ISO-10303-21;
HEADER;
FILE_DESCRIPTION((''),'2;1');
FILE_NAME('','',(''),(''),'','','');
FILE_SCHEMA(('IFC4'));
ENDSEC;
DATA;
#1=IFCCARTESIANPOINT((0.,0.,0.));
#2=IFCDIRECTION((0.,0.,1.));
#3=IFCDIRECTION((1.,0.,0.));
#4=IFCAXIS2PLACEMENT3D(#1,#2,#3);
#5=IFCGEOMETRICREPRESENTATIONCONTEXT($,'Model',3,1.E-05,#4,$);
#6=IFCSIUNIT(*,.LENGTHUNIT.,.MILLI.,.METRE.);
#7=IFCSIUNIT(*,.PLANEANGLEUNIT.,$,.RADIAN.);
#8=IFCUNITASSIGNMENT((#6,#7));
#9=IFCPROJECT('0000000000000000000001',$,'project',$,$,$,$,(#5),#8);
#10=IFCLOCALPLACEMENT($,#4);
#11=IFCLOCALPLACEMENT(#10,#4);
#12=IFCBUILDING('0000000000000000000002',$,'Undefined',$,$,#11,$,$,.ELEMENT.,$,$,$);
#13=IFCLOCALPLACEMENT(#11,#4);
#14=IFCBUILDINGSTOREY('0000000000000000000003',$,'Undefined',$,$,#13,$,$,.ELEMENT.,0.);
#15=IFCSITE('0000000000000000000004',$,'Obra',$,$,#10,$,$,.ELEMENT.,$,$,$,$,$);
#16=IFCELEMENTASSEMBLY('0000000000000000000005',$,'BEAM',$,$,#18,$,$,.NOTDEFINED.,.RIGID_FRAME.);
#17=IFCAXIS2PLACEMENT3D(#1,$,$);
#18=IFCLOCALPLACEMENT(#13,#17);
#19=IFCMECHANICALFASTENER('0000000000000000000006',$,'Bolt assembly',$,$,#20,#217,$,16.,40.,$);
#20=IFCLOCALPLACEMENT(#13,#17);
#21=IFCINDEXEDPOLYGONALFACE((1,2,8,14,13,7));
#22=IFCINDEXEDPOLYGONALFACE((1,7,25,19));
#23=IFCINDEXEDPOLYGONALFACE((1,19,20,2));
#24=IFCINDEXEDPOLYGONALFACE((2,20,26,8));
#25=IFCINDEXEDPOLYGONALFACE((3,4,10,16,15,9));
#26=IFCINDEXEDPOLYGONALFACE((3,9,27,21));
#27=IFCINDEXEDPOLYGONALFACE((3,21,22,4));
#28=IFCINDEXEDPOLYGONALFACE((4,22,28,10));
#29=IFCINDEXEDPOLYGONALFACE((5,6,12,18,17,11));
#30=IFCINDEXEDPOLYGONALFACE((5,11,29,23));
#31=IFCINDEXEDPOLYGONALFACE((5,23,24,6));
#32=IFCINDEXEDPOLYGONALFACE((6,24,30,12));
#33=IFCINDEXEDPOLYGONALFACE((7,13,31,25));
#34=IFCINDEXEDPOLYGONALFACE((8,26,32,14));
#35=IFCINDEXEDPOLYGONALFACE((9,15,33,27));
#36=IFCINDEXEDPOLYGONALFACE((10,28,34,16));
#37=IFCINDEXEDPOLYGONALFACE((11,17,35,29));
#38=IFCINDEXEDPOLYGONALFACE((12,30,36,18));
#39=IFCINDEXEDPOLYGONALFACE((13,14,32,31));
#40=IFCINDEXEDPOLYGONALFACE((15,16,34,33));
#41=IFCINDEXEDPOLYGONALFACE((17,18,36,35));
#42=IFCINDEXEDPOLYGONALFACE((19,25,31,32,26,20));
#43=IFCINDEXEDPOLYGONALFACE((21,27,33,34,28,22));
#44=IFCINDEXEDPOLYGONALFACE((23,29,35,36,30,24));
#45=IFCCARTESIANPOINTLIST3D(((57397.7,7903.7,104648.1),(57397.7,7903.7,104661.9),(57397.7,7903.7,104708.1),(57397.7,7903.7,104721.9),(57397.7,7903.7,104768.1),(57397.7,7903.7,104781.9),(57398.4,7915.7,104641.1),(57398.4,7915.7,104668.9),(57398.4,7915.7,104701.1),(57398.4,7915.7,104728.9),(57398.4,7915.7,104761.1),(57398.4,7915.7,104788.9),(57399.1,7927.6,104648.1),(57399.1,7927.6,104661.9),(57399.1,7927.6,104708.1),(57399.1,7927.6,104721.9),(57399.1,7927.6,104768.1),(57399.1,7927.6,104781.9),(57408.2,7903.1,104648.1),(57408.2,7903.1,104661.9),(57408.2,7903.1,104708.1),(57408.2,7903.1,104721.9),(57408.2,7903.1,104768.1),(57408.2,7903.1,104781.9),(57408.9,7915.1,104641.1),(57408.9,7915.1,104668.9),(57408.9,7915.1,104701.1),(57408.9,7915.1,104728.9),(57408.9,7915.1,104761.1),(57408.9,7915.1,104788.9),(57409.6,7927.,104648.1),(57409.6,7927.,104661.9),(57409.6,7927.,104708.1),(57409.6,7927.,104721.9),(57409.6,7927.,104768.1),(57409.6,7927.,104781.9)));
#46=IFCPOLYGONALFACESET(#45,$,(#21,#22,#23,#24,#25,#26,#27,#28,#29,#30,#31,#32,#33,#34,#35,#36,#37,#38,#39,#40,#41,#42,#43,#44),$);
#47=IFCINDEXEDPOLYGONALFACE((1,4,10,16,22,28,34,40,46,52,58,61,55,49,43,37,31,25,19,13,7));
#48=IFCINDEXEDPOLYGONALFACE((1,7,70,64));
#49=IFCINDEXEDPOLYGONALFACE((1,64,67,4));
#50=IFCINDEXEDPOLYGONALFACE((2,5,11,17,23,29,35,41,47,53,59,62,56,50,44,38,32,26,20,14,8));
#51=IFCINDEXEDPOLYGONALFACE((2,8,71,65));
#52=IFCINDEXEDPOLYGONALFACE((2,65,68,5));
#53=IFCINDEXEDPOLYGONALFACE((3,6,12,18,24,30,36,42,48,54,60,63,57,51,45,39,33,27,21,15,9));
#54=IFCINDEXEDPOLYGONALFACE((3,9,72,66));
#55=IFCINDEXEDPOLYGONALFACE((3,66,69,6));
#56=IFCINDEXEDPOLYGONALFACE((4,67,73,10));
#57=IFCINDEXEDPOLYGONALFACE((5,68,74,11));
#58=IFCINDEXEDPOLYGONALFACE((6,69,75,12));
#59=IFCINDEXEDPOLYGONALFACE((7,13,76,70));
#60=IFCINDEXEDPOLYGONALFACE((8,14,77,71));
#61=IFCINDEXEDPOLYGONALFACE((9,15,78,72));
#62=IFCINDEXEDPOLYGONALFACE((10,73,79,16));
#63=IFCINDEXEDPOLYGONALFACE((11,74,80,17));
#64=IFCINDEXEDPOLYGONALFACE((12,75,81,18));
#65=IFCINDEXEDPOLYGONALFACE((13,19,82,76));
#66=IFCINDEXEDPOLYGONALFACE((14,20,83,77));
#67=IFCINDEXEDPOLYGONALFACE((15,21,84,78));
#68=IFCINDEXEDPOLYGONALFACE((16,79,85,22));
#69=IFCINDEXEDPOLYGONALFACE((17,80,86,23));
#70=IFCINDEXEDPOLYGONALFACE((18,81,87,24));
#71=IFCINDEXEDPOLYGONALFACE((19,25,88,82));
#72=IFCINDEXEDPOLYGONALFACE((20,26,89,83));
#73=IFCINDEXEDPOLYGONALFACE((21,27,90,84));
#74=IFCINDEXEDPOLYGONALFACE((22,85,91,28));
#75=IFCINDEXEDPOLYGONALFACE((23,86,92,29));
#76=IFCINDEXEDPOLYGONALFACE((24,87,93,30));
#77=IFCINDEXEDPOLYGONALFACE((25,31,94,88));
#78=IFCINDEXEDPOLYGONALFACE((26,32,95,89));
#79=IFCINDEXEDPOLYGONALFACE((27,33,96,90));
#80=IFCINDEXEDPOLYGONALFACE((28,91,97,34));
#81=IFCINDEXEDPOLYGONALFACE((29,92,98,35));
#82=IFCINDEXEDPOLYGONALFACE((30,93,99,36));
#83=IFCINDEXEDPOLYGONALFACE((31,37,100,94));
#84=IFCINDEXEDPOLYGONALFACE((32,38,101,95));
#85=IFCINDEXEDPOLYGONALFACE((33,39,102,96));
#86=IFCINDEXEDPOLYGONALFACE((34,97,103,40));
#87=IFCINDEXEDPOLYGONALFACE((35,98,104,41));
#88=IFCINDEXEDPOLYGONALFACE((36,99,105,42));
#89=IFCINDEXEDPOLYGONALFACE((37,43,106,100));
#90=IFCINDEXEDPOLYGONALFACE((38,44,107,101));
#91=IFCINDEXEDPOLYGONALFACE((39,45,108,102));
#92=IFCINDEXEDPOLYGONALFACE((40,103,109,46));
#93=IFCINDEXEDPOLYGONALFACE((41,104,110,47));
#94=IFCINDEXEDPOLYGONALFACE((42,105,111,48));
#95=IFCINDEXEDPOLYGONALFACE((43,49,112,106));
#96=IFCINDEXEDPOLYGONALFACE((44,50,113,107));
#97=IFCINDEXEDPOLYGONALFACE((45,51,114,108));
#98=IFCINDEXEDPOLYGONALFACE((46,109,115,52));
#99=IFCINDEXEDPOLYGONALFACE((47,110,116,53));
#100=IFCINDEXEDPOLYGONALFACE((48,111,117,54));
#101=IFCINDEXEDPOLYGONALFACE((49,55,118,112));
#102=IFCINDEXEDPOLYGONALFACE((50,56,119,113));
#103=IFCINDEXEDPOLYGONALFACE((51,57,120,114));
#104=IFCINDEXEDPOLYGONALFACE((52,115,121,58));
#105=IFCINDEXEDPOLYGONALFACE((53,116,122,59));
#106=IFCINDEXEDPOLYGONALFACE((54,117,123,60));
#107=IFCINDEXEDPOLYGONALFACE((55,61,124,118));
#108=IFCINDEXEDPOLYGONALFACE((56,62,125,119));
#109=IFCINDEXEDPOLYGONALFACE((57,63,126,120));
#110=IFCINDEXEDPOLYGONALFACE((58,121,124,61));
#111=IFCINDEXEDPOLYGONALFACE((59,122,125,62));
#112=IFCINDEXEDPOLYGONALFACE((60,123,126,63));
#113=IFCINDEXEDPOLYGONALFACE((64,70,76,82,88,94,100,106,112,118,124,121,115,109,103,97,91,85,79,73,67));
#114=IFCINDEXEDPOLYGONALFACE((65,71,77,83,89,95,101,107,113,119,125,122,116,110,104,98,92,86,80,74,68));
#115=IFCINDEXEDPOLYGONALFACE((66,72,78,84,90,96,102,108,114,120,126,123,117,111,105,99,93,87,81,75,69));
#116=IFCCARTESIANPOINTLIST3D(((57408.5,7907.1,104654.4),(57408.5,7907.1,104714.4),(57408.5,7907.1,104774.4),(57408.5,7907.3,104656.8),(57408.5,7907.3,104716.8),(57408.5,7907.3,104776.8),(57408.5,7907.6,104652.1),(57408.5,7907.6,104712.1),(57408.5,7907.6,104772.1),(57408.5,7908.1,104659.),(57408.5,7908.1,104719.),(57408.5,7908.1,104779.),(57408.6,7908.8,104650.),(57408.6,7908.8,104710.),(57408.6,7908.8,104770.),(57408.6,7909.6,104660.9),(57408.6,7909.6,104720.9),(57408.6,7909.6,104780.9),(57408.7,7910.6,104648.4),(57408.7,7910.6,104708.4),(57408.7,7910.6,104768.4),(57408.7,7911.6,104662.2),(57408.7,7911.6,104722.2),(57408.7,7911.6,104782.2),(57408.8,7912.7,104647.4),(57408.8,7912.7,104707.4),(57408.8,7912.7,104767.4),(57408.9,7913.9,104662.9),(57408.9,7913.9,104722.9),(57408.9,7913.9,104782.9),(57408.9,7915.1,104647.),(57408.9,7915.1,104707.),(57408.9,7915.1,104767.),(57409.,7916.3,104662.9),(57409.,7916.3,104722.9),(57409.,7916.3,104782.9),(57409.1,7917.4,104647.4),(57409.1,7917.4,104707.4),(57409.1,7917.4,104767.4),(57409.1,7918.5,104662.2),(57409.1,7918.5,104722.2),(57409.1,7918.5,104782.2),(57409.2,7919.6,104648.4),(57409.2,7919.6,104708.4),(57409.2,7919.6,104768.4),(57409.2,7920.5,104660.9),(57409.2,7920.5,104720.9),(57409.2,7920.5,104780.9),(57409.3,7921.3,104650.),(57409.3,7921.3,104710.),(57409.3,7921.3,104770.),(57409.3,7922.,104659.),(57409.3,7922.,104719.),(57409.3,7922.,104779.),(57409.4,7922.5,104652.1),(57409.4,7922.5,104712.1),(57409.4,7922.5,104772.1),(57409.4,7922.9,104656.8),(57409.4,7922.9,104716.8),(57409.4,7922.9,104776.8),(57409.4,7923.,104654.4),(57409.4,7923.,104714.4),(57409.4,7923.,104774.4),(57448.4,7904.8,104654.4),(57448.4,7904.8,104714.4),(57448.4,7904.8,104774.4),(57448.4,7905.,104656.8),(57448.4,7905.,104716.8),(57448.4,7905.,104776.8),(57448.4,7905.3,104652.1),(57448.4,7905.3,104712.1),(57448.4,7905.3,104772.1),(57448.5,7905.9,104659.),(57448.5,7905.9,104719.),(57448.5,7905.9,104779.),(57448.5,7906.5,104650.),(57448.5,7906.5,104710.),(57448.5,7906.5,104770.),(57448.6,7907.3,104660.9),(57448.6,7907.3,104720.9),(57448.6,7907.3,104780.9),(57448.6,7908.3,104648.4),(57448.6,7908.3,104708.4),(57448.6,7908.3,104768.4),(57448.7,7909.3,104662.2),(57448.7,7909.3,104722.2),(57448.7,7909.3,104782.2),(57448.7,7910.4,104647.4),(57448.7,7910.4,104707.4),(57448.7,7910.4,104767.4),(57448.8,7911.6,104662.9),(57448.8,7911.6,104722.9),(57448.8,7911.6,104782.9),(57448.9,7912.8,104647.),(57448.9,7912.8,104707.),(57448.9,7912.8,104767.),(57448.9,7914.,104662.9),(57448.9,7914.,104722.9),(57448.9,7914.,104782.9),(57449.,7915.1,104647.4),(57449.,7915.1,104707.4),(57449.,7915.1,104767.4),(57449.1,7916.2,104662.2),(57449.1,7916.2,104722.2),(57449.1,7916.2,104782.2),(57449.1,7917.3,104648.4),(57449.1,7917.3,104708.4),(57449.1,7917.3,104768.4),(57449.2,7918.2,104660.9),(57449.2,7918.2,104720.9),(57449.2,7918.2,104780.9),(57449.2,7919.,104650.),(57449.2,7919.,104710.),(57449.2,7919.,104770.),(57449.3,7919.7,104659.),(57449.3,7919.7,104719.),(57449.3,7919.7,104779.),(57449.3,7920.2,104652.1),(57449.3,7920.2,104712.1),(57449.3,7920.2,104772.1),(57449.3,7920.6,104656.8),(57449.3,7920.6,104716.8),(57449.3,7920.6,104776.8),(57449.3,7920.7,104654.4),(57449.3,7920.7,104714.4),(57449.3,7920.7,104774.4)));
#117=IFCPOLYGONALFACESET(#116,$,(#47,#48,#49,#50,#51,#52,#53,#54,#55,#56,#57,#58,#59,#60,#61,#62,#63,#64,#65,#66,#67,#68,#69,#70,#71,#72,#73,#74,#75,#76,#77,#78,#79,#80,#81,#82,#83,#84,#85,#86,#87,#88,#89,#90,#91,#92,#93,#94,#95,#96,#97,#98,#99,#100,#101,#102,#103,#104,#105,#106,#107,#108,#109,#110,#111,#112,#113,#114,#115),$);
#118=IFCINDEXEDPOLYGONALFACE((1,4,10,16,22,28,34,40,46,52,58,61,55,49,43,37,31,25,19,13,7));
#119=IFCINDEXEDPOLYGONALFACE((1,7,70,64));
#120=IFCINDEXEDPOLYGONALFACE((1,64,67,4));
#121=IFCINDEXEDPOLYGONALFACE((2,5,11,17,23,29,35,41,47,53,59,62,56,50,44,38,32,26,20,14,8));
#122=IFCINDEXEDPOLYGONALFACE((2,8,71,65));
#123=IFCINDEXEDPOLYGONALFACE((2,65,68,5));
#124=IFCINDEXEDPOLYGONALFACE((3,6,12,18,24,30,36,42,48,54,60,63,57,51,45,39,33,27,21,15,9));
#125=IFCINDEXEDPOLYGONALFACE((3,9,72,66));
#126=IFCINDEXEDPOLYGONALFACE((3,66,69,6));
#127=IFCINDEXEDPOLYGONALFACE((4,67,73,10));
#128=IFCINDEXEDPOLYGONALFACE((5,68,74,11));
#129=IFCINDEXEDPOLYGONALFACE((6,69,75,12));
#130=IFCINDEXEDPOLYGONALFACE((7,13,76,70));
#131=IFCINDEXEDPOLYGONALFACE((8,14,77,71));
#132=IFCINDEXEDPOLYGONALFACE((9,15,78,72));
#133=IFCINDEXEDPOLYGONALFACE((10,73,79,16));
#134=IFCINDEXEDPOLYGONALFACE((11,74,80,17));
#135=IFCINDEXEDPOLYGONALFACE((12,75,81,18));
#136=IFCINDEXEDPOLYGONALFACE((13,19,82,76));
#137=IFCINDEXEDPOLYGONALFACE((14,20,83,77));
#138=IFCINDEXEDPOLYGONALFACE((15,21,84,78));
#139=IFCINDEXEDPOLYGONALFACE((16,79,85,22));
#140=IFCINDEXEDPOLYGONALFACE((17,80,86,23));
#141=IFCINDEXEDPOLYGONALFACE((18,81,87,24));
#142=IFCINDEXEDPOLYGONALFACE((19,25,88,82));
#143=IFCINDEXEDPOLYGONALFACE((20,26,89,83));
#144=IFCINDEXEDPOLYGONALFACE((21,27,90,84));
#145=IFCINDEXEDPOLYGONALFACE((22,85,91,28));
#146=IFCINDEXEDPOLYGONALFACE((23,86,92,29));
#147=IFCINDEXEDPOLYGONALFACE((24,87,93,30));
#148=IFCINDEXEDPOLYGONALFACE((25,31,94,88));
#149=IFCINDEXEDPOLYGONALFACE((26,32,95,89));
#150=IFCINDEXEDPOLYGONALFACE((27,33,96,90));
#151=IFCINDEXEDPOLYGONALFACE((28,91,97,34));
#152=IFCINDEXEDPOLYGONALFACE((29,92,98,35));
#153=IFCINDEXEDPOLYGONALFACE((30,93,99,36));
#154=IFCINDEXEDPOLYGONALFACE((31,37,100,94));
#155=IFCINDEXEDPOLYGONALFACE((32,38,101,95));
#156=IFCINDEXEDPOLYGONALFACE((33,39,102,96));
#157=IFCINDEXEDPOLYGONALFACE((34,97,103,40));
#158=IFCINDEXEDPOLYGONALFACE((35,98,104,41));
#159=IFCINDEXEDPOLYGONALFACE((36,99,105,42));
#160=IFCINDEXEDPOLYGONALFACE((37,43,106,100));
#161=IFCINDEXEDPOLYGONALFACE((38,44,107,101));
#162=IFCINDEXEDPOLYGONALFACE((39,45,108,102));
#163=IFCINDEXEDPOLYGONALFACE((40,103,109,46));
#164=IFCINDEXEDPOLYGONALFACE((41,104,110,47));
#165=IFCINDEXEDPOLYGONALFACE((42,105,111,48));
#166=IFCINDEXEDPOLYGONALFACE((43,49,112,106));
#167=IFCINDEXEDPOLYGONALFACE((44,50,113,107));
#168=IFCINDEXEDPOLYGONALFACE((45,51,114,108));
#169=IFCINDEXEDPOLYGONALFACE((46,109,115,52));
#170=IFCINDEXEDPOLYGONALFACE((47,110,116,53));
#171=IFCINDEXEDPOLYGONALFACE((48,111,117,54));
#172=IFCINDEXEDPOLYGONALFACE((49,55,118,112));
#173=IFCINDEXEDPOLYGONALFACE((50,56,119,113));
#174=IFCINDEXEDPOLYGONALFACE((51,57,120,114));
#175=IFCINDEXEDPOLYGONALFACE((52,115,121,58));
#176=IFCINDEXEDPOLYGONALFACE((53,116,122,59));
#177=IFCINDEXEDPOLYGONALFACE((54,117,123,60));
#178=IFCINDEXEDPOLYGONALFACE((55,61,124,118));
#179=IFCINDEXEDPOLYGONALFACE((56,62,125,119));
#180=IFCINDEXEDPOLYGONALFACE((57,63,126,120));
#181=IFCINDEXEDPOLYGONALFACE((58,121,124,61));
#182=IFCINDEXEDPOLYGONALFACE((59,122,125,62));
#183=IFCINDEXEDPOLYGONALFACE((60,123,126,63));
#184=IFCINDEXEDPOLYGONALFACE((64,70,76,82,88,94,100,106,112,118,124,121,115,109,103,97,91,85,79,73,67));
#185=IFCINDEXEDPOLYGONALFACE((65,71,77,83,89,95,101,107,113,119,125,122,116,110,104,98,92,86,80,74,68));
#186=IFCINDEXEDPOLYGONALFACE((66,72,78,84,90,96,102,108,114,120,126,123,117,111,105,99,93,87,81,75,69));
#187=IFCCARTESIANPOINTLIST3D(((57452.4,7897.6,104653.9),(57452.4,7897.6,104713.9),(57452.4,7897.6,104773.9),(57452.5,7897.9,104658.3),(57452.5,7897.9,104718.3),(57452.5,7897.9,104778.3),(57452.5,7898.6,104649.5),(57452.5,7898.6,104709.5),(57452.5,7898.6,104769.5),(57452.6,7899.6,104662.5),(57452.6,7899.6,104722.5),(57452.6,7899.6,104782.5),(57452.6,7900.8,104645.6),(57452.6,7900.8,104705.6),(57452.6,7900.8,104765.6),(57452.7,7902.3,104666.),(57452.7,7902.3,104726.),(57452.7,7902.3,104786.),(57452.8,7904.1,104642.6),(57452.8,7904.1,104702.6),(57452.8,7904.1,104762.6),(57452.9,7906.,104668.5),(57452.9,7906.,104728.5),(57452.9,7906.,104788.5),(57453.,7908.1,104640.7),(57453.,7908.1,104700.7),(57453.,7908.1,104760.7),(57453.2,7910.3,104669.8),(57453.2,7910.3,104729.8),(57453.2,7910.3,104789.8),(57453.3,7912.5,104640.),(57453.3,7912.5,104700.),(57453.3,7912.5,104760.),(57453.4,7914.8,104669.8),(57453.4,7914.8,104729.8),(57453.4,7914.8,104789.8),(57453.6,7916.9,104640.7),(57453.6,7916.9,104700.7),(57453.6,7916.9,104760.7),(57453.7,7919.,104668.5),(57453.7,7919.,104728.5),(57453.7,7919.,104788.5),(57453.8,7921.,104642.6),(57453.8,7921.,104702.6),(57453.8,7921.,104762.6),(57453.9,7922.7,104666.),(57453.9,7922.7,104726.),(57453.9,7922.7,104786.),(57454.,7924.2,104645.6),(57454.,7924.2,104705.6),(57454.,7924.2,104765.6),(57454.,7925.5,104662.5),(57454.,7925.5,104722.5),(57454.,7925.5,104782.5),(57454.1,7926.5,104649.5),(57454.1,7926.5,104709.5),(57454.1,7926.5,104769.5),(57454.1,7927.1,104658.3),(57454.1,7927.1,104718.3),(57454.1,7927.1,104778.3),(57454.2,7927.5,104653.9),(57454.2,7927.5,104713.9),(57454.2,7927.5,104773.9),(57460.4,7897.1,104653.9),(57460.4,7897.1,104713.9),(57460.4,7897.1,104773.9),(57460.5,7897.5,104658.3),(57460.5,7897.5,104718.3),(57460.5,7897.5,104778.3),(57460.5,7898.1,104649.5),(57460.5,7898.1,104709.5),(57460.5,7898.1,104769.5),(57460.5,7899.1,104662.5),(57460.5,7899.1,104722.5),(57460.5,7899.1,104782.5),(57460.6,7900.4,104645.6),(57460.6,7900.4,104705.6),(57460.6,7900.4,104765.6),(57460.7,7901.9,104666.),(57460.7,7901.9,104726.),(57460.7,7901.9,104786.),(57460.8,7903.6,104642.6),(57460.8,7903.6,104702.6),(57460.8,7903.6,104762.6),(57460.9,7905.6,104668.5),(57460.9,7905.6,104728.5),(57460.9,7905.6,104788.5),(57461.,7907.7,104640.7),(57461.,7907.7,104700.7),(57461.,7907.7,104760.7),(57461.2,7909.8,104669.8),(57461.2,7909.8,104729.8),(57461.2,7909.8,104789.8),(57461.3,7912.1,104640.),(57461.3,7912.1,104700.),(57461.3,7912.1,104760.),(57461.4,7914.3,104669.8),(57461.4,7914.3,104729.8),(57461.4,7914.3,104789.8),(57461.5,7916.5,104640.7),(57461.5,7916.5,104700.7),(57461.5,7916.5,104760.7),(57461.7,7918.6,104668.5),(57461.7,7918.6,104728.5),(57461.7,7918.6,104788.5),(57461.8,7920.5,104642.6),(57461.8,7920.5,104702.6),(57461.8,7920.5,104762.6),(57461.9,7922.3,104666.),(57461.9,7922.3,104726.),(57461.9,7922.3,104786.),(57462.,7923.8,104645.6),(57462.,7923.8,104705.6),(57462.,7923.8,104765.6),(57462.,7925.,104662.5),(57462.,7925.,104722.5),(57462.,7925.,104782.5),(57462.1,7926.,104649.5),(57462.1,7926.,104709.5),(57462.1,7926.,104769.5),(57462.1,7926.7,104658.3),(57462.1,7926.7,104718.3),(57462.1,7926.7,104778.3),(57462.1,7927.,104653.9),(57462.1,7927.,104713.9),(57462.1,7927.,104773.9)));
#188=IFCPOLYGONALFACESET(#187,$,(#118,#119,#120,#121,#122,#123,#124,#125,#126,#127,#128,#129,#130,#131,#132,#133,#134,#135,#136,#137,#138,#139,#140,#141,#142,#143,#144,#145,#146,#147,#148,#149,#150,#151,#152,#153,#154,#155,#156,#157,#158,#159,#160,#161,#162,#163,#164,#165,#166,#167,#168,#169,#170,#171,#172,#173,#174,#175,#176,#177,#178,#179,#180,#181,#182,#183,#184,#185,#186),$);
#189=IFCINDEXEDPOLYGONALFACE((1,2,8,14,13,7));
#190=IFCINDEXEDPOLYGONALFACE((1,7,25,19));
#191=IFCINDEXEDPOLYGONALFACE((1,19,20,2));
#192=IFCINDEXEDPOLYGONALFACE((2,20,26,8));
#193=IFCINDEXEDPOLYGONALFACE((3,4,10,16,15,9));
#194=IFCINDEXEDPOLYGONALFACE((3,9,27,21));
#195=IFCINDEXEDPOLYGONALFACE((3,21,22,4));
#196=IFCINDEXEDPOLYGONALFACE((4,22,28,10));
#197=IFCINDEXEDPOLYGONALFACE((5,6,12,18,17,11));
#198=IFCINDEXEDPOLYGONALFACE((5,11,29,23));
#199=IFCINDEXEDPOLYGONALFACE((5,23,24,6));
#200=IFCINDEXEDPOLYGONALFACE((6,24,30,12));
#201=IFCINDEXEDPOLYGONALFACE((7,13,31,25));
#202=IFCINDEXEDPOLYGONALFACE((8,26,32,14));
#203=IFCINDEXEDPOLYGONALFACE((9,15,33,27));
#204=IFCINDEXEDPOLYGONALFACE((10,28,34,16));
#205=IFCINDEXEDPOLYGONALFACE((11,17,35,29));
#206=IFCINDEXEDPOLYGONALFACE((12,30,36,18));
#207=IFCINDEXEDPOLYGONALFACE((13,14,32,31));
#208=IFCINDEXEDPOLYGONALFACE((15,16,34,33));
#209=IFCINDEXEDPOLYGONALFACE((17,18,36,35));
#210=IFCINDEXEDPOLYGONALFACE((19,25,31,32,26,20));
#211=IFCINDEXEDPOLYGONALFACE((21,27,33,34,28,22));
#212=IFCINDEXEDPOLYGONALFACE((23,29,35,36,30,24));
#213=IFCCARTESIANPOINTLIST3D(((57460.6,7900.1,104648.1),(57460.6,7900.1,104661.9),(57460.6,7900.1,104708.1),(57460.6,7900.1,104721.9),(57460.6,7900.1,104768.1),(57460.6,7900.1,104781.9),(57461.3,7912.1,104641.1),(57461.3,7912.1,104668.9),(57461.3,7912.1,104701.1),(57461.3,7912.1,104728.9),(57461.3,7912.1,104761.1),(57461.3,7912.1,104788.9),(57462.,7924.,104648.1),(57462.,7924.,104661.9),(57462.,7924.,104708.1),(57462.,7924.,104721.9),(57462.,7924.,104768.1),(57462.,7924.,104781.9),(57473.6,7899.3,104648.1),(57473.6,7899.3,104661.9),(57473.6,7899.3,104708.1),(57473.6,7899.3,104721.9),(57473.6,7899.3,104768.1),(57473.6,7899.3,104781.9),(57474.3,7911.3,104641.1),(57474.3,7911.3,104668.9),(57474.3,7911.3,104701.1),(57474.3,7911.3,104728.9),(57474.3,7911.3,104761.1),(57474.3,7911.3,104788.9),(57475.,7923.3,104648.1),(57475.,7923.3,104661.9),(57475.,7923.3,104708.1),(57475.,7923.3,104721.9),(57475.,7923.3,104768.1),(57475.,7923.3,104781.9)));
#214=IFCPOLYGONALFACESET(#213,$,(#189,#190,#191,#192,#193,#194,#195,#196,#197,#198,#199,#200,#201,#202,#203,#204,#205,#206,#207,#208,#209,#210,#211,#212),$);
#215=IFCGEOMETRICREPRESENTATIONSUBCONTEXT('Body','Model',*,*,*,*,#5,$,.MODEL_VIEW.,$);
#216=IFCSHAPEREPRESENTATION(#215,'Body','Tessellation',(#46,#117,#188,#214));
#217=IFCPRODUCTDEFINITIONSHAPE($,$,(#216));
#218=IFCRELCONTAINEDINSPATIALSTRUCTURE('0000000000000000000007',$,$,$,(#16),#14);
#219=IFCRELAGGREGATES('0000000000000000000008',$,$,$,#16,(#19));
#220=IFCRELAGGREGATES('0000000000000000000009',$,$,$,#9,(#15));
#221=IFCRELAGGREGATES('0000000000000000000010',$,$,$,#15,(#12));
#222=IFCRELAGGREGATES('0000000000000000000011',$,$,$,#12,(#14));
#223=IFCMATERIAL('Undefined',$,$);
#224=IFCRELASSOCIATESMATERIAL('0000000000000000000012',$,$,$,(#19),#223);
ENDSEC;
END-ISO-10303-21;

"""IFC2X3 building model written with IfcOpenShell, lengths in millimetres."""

from ifc_helpers import new_model, si_unit, frame, origin_with_axes, origin_2d_with_axis, place, context, subcontext, project, spatial, polyline, circle, outline, extrude, source, transform, mapped, material, element, aggregate, save


model = new_model("IFC2X3")

# Units and contexts
model_context = context("Model", 3, precision=1e-05, world=origin_with_axes())
body_context = subcontext(model_context, "Body", "Model", "MODEL_VIEW")
ifc_project = project(units=[si_unit("LENGTHUNIT", "METRE", prefix="MILLI"), si_unit("PLANEANGLEUNIT", "RADIAN")], contexts=[model_context])

# Site, building, storey
site_placement = place(None, origin_with_axes())
site = spatial("IfcSite", under=ifc_project, at=site_placement, Name="Obra", CompositionType="ELEMENT")
building_placement = place(site_placement, origin_with_axes())
building = spatial("IfcBuilding", under=site, at=building_placement, Name="Undefined", CompositionType="ELEMENT")
storey_placement = place(building_placement, origin_with_axes())
storey = spatial("IfcBuildingStorey", under=building, at=storey_placement, Name="Undefined", CompositionType="ELEMENT", Elevation=0.0)

# Element assembly
assembly_1_placement = place(storey_placement, origin_with_axes())
assembly_1 = element("IfcElementAssembly", 1, at=assembly_1_placement, inside=storey, Name="BEAM", AssemblyPlace="NOTDEFINED", PredefinedType="RIGID_FRAME")
ifc_material_1 = material(Name="Undefined")

# Shared definitions
shared_shape_1 = source(origin_with_axes(), body_context, "Body", "SweptSolid", [
    extrude(outline(polyline([(13.9, 0.0), (6.9, 12.0), (-6.9, 12.0), (-13.9, 0.0), (-6.9, -12.0), (6.9, -12.0), (13.9, 0.0)])), frame((0.0, -19.7, 0.0), z_axis=(0.0, 1.0, 0.0), x_axis=(1.0, 0.0, 0.0)), (0.0, 0.0, 1.0), 10.6),
    extrude(circle(Radius=8.0, at=origin_2d_with_axis()), frame((0.0, -9.1, 0.0), z_axis=(0.0, 1.0, 0.0), x_axis=(1.0, 0.0, 0.0)), (0.0, 0.0, 1.0), 40.0),
    extrude(circle(Radius=15.0, at=origin_2d_with_axis()), frame((0.0, 35.3, 0.0), z_axis=(0.0, 1.0, 0.0), x_axis=(1.0, 0.0, 0.0)), (0.0, 0.0, 1.0), 8.0),
    extrude(outline(polyline([(13.9, 0.0), (6.9, 12.0), (-6.9, 12.0), (-13.9, 0.0), (-6.9, -12.0), (6.9, -12.0), (13.9, 0.0)])), frame((0.0, 43.3, 0.0), z_axis=(0.0, 1.0, 0.0), x_axis=(1.0, 0.0, 0.0)), (0.0, 0.0, 1.0), 13.0),
])

# Mechanical fastener
mechanical_fastener_1_placement = place(assembly_1_placement, frame((57420.9, 7964.5, 104835.0), z_axis=(-0.05711, -0.998368, 0.0), x_axis=(0.0, 0.0, -1.0)))
mechanical_fastener_1 = element("IfcMechanicalFastener", 2, at=mechanical_fastener_1_placement, material=ifc_material_1, Name="Bolt assembly", NominalDiameter=16.0, NominalLength=40.0, context=body_context, shape_type="MappedRepresentation", body=[
    mapped(shared_shape_1, transform((60.0, 0.0, 50.0))),
    mapped(shared_shape_1, transform((120.0, 0.0, 50.0))),
    mapped(shared_shape_1, transform((180.0, 0.0, 50.0))),
])
aggregate(assembly_1, [mechanical_fastener_1])

save(model, "model.ifc")
